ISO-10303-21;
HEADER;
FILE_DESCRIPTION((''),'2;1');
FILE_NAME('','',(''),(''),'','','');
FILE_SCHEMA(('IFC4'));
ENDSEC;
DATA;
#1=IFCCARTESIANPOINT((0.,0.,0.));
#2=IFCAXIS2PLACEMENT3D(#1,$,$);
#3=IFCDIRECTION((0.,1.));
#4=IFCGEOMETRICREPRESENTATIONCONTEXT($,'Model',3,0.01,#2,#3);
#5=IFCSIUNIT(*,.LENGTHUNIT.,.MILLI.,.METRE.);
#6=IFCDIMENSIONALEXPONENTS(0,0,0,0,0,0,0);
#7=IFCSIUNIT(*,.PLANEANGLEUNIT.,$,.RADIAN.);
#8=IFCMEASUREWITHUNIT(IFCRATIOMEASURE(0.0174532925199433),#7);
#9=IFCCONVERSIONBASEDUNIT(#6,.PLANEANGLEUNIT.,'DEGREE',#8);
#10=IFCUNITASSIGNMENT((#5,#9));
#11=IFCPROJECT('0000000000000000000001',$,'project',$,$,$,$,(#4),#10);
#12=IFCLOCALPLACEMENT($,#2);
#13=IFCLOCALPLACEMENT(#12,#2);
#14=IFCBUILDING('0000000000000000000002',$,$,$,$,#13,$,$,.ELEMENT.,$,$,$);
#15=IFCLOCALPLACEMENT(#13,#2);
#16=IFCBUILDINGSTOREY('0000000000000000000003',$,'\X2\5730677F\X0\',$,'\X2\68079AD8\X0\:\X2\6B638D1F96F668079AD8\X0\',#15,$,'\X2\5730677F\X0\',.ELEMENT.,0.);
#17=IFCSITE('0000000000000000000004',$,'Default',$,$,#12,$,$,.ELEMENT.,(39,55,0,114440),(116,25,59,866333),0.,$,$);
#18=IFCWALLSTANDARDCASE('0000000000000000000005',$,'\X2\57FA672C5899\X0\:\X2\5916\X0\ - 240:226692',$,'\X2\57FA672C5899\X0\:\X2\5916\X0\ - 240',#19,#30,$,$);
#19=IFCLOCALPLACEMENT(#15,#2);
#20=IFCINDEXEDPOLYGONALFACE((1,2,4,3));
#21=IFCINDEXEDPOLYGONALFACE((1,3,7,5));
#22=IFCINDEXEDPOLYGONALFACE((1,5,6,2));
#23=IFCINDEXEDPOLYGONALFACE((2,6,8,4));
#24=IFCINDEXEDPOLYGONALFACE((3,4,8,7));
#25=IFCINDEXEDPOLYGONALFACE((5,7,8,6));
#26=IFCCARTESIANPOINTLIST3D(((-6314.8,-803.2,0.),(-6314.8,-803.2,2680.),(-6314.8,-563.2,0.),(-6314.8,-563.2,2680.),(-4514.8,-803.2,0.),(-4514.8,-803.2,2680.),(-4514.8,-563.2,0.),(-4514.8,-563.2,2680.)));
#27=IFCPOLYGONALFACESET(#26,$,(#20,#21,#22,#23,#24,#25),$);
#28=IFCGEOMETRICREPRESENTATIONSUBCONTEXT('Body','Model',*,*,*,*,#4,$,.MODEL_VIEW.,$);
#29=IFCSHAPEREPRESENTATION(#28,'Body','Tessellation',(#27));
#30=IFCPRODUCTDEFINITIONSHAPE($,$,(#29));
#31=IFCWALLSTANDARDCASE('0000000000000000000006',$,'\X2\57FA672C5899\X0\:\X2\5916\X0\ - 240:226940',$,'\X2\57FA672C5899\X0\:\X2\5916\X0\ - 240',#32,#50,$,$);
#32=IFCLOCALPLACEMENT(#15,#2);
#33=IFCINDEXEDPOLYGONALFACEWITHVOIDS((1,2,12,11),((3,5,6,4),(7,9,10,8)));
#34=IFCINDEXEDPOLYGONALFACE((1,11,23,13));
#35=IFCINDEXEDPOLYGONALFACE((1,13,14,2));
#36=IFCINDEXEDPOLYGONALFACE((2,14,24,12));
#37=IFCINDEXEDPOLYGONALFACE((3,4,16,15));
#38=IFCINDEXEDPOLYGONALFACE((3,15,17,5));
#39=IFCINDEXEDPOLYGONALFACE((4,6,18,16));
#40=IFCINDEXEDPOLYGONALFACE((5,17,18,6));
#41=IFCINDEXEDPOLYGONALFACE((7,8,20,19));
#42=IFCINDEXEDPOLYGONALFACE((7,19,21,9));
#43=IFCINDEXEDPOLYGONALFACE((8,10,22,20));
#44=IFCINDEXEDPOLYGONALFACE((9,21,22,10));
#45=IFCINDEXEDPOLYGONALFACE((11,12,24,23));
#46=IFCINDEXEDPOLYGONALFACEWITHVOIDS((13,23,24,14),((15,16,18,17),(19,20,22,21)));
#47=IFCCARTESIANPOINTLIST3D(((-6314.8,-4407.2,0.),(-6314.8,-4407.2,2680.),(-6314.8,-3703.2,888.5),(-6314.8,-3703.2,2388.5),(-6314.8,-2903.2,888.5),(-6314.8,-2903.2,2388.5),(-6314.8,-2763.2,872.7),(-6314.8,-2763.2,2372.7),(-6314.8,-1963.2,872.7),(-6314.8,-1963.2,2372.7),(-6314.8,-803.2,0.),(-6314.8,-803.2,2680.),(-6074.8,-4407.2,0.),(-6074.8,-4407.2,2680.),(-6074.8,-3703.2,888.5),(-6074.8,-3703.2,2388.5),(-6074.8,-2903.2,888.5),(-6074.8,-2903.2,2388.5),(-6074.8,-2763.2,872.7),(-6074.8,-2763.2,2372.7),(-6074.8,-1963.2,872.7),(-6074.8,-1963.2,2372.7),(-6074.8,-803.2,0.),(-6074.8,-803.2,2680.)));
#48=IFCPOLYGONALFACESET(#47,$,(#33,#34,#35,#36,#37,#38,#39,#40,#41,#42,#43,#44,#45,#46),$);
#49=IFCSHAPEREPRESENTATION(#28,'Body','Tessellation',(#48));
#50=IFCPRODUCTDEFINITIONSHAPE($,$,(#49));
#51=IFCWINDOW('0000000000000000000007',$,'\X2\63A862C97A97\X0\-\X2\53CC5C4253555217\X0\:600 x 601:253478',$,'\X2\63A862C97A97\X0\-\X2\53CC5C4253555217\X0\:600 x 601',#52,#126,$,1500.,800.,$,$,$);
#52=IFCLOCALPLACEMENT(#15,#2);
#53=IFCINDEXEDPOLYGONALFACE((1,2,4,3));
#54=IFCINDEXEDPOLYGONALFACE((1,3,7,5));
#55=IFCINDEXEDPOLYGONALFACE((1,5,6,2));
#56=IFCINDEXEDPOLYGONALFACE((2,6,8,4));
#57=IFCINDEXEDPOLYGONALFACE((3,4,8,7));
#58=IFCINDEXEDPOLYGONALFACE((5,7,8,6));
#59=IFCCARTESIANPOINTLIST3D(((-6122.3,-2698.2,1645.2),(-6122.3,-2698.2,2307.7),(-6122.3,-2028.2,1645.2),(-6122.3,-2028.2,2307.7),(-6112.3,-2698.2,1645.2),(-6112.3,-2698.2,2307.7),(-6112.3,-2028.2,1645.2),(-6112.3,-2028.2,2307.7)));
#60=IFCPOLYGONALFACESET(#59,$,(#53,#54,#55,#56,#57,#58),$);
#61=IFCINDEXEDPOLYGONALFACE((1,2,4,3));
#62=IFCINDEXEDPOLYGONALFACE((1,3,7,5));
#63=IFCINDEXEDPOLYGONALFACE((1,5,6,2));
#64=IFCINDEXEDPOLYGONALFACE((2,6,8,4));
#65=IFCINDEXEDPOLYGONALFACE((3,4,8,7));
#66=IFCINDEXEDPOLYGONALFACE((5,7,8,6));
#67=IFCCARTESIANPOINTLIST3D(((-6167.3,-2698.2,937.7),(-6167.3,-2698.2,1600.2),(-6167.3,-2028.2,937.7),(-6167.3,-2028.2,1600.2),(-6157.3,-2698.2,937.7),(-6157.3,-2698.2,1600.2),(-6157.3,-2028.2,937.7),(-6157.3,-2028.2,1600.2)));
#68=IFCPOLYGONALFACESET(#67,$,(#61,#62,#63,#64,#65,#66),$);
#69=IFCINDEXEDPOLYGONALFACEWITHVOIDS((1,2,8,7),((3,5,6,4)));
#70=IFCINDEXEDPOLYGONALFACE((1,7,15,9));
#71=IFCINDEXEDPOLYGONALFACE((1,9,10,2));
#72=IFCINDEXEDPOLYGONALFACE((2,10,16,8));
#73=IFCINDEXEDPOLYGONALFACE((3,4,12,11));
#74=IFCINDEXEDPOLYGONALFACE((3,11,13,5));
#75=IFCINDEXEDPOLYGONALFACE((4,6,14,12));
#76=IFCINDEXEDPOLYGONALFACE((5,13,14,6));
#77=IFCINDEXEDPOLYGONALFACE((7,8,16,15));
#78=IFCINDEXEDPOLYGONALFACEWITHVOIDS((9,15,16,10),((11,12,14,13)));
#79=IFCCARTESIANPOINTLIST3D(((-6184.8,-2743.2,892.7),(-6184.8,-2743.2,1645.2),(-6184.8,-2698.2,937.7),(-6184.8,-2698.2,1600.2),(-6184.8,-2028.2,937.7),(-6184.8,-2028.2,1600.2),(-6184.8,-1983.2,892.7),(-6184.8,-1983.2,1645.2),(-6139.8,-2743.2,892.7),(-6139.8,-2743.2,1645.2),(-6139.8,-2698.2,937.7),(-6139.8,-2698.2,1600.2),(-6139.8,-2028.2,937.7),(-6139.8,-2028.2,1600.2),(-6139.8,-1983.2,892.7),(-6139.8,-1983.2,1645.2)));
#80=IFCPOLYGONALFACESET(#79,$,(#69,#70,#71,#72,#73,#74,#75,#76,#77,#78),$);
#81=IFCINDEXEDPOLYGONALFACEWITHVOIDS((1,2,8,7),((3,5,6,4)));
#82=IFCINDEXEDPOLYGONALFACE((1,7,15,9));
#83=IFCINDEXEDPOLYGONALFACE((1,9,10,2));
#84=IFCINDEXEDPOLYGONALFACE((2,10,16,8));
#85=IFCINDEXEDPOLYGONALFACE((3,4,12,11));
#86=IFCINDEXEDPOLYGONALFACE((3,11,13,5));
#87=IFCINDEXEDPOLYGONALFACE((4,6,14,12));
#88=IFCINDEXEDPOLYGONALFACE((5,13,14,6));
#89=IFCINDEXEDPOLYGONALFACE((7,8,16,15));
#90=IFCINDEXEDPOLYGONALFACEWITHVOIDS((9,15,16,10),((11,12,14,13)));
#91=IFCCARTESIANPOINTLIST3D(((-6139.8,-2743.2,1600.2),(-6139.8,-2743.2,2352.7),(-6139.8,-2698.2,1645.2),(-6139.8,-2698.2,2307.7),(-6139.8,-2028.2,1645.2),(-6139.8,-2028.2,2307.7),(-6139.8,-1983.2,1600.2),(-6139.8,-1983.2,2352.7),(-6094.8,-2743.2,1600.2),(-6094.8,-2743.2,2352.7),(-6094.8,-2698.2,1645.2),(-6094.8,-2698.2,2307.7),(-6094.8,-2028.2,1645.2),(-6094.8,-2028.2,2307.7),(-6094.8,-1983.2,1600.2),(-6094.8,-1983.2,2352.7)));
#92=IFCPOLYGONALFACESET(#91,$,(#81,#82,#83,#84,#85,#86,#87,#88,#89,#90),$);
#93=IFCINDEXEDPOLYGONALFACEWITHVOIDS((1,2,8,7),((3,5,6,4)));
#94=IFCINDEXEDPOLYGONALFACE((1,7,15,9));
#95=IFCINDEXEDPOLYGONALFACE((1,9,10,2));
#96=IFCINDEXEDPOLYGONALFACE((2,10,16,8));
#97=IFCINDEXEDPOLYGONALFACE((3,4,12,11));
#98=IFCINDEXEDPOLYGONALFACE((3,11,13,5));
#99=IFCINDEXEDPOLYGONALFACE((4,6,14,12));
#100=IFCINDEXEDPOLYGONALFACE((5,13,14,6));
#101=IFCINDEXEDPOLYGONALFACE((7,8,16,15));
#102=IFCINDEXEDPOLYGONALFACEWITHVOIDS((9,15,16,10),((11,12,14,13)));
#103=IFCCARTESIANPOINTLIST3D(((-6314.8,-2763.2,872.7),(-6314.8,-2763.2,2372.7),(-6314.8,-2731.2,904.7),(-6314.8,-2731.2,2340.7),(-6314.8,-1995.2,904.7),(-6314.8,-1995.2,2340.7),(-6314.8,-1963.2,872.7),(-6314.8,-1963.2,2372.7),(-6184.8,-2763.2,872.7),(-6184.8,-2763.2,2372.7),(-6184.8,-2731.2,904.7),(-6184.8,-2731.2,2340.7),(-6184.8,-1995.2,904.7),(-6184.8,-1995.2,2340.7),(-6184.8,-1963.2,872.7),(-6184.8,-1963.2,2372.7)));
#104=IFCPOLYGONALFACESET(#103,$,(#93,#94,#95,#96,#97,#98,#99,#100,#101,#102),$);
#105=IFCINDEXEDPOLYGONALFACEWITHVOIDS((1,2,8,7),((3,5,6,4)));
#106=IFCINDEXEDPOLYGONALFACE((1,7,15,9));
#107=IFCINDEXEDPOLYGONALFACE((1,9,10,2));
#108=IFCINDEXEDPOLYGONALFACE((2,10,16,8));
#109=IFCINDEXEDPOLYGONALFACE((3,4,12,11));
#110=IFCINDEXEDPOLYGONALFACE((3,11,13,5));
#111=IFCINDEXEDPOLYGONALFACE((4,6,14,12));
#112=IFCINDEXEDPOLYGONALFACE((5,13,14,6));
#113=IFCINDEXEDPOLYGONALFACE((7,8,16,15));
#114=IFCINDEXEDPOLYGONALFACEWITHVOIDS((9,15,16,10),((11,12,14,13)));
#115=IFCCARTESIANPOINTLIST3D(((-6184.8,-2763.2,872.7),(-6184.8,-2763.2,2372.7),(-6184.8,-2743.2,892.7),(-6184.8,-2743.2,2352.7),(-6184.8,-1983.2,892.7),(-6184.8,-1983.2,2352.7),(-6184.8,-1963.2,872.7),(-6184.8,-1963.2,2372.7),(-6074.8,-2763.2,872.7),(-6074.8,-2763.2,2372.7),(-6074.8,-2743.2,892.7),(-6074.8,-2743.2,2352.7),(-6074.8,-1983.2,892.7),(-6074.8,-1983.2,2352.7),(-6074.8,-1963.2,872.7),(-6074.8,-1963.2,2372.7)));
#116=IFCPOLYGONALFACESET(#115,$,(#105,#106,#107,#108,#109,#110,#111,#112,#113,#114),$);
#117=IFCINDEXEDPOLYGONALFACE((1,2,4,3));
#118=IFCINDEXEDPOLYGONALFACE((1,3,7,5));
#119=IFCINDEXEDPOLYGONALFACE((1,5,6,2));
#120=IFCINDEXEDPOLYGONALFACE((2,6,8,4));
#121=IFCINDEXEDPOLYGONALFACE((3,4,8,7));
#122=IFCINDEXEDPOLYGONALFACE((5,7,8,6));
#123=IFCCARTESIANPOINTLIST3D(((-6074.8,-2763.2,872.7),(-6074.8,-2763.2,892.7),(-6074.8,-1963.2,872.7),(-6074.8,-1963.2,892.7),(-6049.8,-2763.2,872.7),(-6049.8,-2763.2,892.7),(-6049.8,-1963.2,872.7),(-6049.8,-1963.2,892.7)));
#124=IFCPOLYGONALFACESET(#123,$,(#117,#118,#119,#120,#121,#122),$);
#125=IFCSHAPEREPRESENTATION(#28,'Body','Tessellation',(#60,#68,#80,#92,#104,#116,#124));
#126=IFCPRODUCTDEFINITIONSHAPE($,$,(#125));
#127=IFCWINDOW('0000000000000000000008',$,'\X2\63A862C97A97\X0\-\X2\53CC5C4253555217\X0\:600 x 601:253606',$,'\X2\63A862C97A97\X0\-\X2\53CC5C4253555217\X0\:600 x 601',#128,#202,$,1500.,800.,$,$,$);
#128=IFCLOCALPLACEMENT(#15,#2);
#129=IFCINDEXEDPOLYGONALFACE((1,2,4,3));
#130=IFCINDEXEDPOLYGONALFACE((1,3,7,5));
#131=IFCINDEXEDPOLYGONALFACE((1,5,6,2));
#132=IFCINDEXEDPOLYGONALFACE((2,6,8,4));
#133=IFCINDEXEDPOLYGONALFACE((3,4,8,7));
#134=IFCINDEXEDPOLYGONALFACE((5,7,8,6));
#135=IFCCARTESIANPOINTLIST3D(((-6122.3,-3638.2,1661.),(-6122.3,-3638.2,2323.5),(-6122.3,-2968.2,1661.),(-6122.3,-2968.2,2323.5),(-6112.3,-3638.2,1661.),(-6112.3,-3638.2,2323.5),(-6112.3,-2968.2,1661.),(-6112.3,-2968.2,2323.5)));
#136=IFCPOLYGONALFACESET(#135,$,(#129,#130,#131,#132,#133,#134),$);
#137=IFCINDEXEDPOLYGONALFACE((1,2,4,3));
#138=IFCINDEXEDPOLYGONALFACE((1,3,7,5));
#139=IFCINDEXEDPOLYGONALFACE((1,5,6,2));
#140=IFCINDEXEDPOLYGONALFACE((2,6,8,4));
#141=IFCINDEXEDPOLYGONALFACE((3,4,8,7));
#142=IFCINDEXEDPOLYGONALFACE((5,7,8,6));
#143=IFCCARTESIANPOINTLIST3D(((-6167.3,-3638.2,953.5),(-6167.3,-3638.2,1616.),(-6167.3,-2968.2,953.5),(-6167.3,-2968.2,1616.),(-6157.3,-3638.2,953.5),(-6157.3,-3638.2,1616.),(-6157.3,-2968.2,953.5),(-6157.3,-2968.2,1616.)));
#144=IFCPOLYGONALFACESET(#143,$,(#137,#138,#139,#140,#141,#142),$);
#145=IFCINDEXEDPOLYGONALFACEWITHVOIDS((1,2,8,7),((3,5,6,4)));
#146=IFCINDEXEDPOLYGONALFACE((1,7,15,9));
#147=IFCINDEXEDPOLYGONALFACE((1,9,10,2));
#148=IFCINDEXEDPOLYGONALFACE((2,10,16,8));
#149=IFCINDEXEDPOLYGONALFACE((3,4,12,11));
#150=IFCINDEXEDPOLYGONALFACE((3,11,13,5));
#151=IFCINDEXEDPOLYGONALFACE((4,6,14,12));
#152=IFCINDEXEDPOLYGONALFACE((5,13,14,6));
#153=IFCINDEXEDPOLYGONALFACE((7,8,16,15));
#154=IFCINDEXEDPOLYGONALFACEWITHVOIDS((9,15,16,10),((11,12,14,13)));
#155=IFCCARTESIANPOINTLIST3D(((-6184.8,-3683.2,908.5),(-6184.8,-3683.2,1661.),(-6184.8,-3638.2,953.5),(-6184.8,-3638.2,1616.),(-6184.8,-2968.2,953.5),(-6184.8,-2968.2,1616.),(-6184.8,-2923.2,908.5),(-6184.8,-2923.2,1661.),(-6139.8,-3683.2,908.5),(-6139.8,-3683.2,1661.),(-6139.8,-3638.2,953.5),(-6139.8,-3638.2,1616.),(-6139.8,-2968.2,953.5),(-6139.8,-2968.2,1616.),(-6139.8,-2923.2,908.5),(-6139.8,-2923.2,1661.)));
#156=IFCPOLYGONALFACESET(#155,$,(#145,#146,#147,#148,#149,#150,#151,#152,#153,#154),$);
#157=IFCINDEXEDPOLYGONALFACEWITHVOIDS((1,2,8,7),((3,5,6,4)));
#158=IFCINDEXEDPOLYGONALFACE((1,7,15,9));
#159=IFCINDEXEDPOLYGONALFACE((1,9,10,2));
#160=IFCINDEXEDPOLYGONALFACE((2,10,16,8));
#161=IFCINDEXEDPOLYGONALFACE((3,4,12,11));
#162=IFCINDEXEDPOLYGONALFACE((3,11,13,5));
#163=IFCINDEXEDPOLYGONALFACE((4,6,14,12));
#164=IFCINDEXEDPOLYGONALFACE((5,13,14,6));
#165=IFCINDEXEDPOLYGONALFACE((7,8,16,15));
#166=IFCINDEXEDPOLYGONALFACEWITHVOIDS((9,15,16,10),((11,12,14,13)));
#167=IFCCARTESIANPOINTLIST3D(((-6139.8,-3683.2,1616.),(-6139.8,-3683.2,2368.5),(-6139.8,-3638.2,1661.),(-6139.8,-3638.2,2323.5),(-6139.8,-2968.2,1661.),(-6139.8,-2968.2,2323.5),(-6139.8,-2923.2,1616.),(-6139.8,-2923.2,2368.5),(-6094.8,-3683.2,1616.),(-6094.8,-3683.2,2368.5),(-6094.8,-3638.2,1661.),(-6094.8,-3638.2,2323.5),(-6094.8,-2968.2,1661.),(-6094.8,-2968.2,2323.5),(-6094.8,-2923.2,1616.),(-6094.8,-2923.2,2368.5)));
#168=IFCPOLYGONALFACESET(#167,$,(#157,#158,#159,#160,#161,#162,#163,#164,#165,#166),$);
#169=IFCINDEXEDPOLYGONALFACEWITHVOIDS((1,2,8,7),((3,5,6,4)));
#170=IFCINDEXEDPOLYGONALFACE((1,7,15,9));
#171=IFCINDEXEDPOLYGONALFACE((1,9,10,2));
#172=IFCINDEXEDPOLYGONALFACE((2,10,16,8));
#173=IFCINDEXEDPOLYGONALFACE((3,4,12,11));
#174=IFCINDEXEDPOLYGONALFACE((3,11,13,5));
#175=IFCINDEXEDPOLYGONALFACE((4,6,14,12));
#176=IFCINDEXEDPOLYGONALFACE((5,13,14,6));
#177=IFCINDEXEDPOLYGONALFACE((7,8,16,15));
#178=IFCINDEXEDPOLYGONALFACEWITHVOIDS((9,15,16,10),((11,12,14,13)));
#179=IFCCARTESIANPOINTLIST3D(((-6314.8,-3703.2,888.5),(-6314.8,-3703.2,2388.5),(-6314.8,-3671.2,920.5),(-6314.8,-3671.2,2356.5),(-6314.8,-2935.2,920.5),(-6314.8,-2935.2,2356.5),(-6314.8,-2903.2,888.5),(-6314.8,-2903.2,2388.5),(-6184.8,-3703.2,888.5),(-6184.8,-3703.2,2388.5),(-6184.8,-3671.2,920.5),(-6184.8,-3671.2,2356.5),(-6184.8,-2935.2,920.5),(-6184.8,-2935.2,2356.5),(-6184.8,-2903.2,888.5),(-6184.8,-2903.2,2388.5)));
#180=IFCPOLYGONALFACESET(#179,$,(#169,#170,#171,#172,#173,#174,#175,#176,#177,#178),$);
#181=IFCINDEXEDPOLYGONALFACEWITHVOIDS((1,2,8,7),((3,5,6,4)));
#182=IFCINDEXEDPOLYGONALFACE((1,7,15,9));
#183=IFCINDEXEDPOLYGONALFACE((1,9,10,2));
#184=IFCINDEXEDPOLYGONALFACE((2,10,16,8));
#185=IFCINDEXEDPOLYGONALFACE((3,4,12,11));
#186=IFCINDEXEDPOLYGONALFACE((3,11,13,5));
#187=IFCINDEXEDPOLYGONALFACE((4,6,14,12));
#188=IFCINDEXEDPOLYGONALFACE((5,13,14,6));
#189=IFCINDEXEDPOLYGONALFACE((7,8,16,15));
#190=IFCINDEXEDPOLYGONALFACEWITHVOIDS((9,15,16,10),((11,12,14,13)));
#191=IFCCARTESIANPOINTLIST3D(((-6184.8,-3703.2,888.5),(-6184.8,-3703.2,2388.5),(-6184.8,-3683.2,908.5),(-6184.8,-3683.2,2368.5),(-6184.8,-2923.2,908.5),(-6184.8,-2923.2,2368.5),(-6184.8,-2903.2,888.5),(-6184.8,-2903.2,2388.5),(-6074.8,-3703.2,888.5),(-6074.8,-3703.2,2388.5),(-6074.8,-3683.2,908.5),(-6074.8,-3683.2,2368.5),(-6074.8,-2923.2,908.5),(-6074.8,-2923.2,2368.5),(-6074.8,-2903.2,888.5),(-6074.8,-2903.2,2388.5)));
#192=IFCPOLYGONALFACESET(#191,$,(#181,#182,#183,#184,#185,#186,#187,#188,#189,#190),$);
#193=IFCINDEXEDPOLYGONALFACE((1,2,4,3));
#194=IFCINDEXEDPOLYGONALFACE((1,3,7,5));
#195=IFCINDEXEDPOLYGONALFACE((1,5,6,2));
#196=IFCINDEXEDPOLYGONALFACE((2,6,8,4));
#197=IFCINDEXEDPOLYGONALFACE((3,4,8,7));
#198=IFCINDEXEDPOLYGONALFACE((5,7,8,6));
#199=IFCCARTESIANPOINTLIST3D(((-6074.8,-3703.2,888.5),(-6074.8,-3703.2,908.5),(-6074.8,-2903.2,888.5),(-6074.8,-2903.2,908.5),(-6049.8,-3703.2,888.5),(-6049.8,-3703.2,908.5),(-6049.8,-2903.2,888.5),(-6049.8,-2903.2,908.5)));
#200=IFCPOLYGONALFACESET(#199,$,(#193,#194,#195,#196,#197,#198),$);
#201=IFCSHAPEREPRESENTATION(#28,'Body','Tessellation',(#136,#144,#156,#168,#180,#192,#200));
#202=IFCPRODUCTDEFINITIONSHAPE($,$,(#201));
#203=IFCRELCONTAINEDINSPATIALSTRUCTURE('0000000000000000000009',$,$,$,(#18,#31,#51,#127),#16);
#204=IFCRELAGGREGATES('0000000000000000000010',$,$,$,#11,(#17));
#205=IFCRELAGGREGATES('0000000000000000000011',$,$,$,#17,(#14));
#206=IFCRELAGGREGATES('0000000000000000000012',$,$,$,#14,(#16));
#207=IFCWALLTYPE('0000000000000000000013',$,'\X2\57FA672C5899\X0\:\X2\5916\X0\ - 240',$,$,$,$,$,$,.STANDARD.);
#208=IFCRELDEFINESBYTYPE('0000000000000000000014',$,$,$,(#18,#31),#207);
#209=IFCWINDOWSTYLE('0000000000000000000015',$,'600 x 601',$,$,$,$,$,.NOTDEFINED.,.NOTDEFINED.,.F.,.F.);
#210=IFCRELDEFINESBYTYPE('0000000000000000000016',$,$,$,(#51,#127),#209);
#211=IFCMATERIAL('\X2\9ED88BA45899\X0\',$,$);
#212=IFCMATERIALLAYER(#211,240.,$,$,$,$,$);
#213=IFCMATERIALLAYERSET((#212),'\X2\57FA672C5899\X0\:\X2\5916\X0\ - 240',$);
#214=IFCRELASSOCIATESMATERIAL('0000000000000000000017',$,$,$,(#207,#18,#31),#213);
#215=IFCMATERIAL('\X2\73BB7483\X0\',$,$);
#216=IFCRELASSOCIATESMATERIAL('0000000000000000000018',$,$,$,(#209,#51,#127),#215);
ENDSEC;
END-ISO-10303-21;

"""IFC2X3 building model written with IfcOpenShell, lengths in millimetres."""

from ifc_helpers import new_model, entity, si_unit, converted_unit, direction, frame, frame_2d, origin, origin_2d_with_axis, place, context, subcontext, project, spatial, polyline, rectangle, outline, extrude, source, transform, mapped, material, layer, layer_set, layer_usage, type_object, type_shapes, element, fill, save


model = new_model("IFC2X3")

# Units and contexts
model_context = context("Model", 3, precision=0.01, world=origin(), true_north=direction((0.0, 1.0)))
body_context = subcontext(model_context, "Body", "Model", "MODEL_VIEW")
ifc_project = project(units=[si_unit("LENGTHUNIT", "METRE", prefix="MILLI"), converted_unit("PLANEANGLEUNIT", "DEGREE", entity("IfcRatioMeasure", 0.0174532925199433), si_unit("PLANEANGLEUNIT", "RADIAN"), dimensions=[0, 0, 0, 0, 0, 0, 0])], contexts=[model_context])

# Site, building, storey
site_placement = place(None, origin())
site = spatial("IfcSite", under=ifc_project, at=site_placement, Name="Default", CompositionType="ELEMENT", RefLatitude=(39, 55, 0, 114440), RefLongitude=(116, 25, 59, 866333), RefElevation=0.0)
building_placement = place(site_placement, origin())
building = spatial("IfcBuilding", under=site, at=building_placement, CompositionType="ELEMENT")
storey_placement = place(building_placement, origin())
storey = spatial("IfcBuildingStorey", under=building, at=storey_placement, Name="地板", ObjectType="标高:正负零标高", LongName="地板", CompositionType="ELEMENT", Elevation=0.0)

# Wall
ifc_material_1 = material(Name="默认墙")
ifc_layer = layer(ifc_material_1, 240.0)
ifc_layer_set = layer_set([ifc_layer], Name="基本墙:外 - 240")
ifc_layer_usage_1 = layer_usage(ifc_layer_set, "AXIS2", "NEGATIVE", 120.0)
wall_type = type_object("IfcWallType", Name="基本墙:外 - 240", PredefinedType="STANDARD", material=ifc_layer_set)
wall_1_placement = place(storey_placement, frame((-4514.8, -683.2, 0.0), z_axis=(0.0, 0.0, 1.0), x_axis=(-1.0, 0.0, 0.0)))
element("IfcWallStandardCase", 1, at=wall_1_placement, inside=storey, type_object=wall_type, material=ifc_layer_usage_1, Name="基本墙:外 - 240:226692", ObjectType="基本墙:外 - 240", context=body_context, shape_type="SweptSolid", body=[
    extrude(rectangle(XDim=1800.0, YDim=240.0, at=frame_2d((900.0, 0.0), x_axis=(-1.0, 0.0))), origin(), (0.0, 0.0, 1.0), 2680.0),
])

# Wall, openings, windows
ifc_layer_usage_2 = layer_usage(ifc_layer_set, "AXIS2", "NEGATIVE", 120.0)
wall_2_placement = place(storey_placement, frame((-6194.8, -803.2, 0.0), z_axis=(0.0, 0.0, 1.0), x_axis=(0.0, -1.0, 0.0)))
wall_2 = element("IfcWallStandardCase", 2, at=wall_2_placement, inside=storey, type_object=wall_type, material=ifc_layer_usage_2, Name="基本墙:外 - 240:226940", ObjectType="基本墙:外 - 240", context=body_context, shape_type="SweptSolid", body=[
    extrude(rectangle(XDim=3604.0, YDim=240.0, at=frame_2d((1802.0, 0.0), x_axis=(-1.0, 0.0))), origin(), (0.0, 0.0, 1.0), 2680.0),
])
opening_1_placement = place(wall_2_placement, frame((2100.0, -120.0, 888.5)))
opening_1 = element("IfcOpeningElement", 3, at=opening_1_placement, cuts=wall_2, ObjectType="Opening", context=body_context, shape_type="SweptSolid", body=[
    extrude(rectangle(XDim=1500.0, YDim=800.0, at=frame_2d((750.0, 400.0), x_axis=(-1.0, 0.0))), frame((0.0, 0.0, 0.0), z_axis=(0.0, 1.0, 0.0), x_axis=(0.0, 0.0, 1.0)), (0.0, 0.0, 1.0), 240.0),
])
opening_2_placement = place(wall_2_placement, frame((1160.0, -120.0, 872.7)))
opening_2 = element("IfcOpeningElement", 4, at=opening_2_placement, cuts=wall_2, ObjectType="Opening", context=body_context, shape_type="SweptSolid", body=[
    extrude(rectangle(XDim=1500.0, YDim=800.0, at=frame_2d((750.0, 400.0), x_axis=(-1.0, 0.0))), frame((0.0, 0.0, 0.0), z_axis=(0.0, 1.0, 0.0), x_axis=(0.0, 0.0, 1.0)), (0.0, 0.0, 1.0), 240.0),
])
ifc_material_2 = material(Name="玻璃")
window_style_1 = type_object("IfcWindowStyle", Name="600 x 601", ConstructionType="NOTDEFINED", OperationType="NOTDEFINED", ParameterTakesPrecedence=False, Sizeable=False, material=ifc_material_2)
shared_shape_1 = source(origin(), body_context, "Body", "SweptSolid", [
    extrude(rectangle(XDim=10.0, YDim=670.0, at=origin_2d_with_axis()), frame((400.0, 197.5, 772.5), z_axis=(0.0, 0.0, 1.0), x_axis=(0.0, -1.0, 0.0)), (0.0, 0.0, 1.0), 662.5),
    extrude(rectangle(XDim=10.0, YDim=670.0, at=origin_2d_with_axis()), frame((400.0, 152.5, 65.0), z_axis=(0.0, 0.0, 1.0), x_axis=(0.0, -1.0, 0.0)), (0.0, 0.0, 1.0), 662.5),
    extrude(outline(polyline([(-380.0, -376.2), (380.0, -376.2), (380.0, 376.2), (-380.0, 376.2), (-380.0, -376.2)]), holes=[polyline([(-335.0, -331.2), (-335.0, 331.2), (335.0, 331.2), (335.0, -331.2), (-335.0, -331.2)])]), frame((400.0, 130.0, 396.3), z_axis=(0.0, 1.0, 0.0), x_axis=(1.0, 0.0, 0.0)), (0.0, 0.0, 1.0), 45.0),
    extrude(outline(polyline([(-380.0, -376.2), (380.0, -376.2), (380.0, 376.2), (-380.0, 376.2), (-380.0, -376.2)]), holes=[polyline([(-335.0, -331.2), (-335.0, 331.2), (335.0, 331.2), (335.0, -331.2), (-335.0, -331.2)])]), frame((400.0, 175.0, 1103.8), z_axis=(0.0, 1.0, 0.0), x_axis=(1.0, 0.0, 0.0)), (0.0, 0.0, 1.0), 45.0),
    extrude(outline(polyline([(-400.0, -750.0), (400.0, -750.0), (400.0, 750.0), (-400.0, 750.0), (-400.0, -750.0)]), holes=[polyline([(-368.0, -718.0), (-368.0, 718.0), (368.0, 718.0), (368.0, -718.0), (-368.0, -718.0)])]), frame((400.0, 0.0, 750.0), z_axis=(0.0, 1.0, 0.0), x_axis=(1.0, 0.0, 0.0)), (0.0, 0.0, 1.0), 130.0),
    extrude(outline(polyline([(-750.0, -400.0), (750.0, -400.0), (750.0, 400.0), (-750.0, 400.0), (-750.0, -400.0)]), holes=[polyline([(-730.0, -380.0), (-730.0, 380.0), (730.0, 380.0), (730.0, -380.0), (-730.0, -380.0)])]), frame((400.0, 130.0, 750.0), z_axis=(0.0, 1.0, 0.0), x_axis=(0.0, 0.0, -1.0)), (0.0, 0.0, 1.0), 110.0),
    extrude(rectangle(XDim=25.0, YDim=800.0, at=origin_2d_with_axis()), frame((400.0, 252.5, 0.0), z_axis=(0.0, 0.0, 1.0), x_axis=(0.0, -1.0, 0.0)), (0.0, 0.0, 1.0), 20.0),
])
type_shapes(window_style_1, [shared_shape_1])
window_1_placement = place(opening_2_placement, origin())
window_1 = element("IfcWindow", 5, at=window_1_placement, inside=storey, type_object=window_style_1, material=ifc_material_2, Name="推拉窗-双层单列:600 x 601:253478", ObjectType="推拉窗-双层单列:600 x 601", OverallHeight=1500.0, OverallWidth=800.0, context=body_context, shape_type="MappedRepresentation", body=[
    mapped(shared_shape_1, transform((0.0, 0.0, 0.0), scale=1.0)),
])
fill(opening_2, window_1)
window_2_placement = place(opening_1_placement, origin())
window_2 = element("IfcWindow", 6, at=window_2_placement, inside=storey, type_object=window_style_1, material=ifc_material_2, Name="推拉窗-双层单列:600 x 601:253606", ObjectType="推拉窗-双层单列:600 x 601", OverallHeight=1500.0, OverallWidth=800.0, context=body_context, shape_type="MappedRepresentation", body=[
    mapped(shared_shape_1, transform((0.0, 0.0, 0.0), scale=1.0)),
])
fill(opening_1, window_2)

save(model, "model.ifc")
